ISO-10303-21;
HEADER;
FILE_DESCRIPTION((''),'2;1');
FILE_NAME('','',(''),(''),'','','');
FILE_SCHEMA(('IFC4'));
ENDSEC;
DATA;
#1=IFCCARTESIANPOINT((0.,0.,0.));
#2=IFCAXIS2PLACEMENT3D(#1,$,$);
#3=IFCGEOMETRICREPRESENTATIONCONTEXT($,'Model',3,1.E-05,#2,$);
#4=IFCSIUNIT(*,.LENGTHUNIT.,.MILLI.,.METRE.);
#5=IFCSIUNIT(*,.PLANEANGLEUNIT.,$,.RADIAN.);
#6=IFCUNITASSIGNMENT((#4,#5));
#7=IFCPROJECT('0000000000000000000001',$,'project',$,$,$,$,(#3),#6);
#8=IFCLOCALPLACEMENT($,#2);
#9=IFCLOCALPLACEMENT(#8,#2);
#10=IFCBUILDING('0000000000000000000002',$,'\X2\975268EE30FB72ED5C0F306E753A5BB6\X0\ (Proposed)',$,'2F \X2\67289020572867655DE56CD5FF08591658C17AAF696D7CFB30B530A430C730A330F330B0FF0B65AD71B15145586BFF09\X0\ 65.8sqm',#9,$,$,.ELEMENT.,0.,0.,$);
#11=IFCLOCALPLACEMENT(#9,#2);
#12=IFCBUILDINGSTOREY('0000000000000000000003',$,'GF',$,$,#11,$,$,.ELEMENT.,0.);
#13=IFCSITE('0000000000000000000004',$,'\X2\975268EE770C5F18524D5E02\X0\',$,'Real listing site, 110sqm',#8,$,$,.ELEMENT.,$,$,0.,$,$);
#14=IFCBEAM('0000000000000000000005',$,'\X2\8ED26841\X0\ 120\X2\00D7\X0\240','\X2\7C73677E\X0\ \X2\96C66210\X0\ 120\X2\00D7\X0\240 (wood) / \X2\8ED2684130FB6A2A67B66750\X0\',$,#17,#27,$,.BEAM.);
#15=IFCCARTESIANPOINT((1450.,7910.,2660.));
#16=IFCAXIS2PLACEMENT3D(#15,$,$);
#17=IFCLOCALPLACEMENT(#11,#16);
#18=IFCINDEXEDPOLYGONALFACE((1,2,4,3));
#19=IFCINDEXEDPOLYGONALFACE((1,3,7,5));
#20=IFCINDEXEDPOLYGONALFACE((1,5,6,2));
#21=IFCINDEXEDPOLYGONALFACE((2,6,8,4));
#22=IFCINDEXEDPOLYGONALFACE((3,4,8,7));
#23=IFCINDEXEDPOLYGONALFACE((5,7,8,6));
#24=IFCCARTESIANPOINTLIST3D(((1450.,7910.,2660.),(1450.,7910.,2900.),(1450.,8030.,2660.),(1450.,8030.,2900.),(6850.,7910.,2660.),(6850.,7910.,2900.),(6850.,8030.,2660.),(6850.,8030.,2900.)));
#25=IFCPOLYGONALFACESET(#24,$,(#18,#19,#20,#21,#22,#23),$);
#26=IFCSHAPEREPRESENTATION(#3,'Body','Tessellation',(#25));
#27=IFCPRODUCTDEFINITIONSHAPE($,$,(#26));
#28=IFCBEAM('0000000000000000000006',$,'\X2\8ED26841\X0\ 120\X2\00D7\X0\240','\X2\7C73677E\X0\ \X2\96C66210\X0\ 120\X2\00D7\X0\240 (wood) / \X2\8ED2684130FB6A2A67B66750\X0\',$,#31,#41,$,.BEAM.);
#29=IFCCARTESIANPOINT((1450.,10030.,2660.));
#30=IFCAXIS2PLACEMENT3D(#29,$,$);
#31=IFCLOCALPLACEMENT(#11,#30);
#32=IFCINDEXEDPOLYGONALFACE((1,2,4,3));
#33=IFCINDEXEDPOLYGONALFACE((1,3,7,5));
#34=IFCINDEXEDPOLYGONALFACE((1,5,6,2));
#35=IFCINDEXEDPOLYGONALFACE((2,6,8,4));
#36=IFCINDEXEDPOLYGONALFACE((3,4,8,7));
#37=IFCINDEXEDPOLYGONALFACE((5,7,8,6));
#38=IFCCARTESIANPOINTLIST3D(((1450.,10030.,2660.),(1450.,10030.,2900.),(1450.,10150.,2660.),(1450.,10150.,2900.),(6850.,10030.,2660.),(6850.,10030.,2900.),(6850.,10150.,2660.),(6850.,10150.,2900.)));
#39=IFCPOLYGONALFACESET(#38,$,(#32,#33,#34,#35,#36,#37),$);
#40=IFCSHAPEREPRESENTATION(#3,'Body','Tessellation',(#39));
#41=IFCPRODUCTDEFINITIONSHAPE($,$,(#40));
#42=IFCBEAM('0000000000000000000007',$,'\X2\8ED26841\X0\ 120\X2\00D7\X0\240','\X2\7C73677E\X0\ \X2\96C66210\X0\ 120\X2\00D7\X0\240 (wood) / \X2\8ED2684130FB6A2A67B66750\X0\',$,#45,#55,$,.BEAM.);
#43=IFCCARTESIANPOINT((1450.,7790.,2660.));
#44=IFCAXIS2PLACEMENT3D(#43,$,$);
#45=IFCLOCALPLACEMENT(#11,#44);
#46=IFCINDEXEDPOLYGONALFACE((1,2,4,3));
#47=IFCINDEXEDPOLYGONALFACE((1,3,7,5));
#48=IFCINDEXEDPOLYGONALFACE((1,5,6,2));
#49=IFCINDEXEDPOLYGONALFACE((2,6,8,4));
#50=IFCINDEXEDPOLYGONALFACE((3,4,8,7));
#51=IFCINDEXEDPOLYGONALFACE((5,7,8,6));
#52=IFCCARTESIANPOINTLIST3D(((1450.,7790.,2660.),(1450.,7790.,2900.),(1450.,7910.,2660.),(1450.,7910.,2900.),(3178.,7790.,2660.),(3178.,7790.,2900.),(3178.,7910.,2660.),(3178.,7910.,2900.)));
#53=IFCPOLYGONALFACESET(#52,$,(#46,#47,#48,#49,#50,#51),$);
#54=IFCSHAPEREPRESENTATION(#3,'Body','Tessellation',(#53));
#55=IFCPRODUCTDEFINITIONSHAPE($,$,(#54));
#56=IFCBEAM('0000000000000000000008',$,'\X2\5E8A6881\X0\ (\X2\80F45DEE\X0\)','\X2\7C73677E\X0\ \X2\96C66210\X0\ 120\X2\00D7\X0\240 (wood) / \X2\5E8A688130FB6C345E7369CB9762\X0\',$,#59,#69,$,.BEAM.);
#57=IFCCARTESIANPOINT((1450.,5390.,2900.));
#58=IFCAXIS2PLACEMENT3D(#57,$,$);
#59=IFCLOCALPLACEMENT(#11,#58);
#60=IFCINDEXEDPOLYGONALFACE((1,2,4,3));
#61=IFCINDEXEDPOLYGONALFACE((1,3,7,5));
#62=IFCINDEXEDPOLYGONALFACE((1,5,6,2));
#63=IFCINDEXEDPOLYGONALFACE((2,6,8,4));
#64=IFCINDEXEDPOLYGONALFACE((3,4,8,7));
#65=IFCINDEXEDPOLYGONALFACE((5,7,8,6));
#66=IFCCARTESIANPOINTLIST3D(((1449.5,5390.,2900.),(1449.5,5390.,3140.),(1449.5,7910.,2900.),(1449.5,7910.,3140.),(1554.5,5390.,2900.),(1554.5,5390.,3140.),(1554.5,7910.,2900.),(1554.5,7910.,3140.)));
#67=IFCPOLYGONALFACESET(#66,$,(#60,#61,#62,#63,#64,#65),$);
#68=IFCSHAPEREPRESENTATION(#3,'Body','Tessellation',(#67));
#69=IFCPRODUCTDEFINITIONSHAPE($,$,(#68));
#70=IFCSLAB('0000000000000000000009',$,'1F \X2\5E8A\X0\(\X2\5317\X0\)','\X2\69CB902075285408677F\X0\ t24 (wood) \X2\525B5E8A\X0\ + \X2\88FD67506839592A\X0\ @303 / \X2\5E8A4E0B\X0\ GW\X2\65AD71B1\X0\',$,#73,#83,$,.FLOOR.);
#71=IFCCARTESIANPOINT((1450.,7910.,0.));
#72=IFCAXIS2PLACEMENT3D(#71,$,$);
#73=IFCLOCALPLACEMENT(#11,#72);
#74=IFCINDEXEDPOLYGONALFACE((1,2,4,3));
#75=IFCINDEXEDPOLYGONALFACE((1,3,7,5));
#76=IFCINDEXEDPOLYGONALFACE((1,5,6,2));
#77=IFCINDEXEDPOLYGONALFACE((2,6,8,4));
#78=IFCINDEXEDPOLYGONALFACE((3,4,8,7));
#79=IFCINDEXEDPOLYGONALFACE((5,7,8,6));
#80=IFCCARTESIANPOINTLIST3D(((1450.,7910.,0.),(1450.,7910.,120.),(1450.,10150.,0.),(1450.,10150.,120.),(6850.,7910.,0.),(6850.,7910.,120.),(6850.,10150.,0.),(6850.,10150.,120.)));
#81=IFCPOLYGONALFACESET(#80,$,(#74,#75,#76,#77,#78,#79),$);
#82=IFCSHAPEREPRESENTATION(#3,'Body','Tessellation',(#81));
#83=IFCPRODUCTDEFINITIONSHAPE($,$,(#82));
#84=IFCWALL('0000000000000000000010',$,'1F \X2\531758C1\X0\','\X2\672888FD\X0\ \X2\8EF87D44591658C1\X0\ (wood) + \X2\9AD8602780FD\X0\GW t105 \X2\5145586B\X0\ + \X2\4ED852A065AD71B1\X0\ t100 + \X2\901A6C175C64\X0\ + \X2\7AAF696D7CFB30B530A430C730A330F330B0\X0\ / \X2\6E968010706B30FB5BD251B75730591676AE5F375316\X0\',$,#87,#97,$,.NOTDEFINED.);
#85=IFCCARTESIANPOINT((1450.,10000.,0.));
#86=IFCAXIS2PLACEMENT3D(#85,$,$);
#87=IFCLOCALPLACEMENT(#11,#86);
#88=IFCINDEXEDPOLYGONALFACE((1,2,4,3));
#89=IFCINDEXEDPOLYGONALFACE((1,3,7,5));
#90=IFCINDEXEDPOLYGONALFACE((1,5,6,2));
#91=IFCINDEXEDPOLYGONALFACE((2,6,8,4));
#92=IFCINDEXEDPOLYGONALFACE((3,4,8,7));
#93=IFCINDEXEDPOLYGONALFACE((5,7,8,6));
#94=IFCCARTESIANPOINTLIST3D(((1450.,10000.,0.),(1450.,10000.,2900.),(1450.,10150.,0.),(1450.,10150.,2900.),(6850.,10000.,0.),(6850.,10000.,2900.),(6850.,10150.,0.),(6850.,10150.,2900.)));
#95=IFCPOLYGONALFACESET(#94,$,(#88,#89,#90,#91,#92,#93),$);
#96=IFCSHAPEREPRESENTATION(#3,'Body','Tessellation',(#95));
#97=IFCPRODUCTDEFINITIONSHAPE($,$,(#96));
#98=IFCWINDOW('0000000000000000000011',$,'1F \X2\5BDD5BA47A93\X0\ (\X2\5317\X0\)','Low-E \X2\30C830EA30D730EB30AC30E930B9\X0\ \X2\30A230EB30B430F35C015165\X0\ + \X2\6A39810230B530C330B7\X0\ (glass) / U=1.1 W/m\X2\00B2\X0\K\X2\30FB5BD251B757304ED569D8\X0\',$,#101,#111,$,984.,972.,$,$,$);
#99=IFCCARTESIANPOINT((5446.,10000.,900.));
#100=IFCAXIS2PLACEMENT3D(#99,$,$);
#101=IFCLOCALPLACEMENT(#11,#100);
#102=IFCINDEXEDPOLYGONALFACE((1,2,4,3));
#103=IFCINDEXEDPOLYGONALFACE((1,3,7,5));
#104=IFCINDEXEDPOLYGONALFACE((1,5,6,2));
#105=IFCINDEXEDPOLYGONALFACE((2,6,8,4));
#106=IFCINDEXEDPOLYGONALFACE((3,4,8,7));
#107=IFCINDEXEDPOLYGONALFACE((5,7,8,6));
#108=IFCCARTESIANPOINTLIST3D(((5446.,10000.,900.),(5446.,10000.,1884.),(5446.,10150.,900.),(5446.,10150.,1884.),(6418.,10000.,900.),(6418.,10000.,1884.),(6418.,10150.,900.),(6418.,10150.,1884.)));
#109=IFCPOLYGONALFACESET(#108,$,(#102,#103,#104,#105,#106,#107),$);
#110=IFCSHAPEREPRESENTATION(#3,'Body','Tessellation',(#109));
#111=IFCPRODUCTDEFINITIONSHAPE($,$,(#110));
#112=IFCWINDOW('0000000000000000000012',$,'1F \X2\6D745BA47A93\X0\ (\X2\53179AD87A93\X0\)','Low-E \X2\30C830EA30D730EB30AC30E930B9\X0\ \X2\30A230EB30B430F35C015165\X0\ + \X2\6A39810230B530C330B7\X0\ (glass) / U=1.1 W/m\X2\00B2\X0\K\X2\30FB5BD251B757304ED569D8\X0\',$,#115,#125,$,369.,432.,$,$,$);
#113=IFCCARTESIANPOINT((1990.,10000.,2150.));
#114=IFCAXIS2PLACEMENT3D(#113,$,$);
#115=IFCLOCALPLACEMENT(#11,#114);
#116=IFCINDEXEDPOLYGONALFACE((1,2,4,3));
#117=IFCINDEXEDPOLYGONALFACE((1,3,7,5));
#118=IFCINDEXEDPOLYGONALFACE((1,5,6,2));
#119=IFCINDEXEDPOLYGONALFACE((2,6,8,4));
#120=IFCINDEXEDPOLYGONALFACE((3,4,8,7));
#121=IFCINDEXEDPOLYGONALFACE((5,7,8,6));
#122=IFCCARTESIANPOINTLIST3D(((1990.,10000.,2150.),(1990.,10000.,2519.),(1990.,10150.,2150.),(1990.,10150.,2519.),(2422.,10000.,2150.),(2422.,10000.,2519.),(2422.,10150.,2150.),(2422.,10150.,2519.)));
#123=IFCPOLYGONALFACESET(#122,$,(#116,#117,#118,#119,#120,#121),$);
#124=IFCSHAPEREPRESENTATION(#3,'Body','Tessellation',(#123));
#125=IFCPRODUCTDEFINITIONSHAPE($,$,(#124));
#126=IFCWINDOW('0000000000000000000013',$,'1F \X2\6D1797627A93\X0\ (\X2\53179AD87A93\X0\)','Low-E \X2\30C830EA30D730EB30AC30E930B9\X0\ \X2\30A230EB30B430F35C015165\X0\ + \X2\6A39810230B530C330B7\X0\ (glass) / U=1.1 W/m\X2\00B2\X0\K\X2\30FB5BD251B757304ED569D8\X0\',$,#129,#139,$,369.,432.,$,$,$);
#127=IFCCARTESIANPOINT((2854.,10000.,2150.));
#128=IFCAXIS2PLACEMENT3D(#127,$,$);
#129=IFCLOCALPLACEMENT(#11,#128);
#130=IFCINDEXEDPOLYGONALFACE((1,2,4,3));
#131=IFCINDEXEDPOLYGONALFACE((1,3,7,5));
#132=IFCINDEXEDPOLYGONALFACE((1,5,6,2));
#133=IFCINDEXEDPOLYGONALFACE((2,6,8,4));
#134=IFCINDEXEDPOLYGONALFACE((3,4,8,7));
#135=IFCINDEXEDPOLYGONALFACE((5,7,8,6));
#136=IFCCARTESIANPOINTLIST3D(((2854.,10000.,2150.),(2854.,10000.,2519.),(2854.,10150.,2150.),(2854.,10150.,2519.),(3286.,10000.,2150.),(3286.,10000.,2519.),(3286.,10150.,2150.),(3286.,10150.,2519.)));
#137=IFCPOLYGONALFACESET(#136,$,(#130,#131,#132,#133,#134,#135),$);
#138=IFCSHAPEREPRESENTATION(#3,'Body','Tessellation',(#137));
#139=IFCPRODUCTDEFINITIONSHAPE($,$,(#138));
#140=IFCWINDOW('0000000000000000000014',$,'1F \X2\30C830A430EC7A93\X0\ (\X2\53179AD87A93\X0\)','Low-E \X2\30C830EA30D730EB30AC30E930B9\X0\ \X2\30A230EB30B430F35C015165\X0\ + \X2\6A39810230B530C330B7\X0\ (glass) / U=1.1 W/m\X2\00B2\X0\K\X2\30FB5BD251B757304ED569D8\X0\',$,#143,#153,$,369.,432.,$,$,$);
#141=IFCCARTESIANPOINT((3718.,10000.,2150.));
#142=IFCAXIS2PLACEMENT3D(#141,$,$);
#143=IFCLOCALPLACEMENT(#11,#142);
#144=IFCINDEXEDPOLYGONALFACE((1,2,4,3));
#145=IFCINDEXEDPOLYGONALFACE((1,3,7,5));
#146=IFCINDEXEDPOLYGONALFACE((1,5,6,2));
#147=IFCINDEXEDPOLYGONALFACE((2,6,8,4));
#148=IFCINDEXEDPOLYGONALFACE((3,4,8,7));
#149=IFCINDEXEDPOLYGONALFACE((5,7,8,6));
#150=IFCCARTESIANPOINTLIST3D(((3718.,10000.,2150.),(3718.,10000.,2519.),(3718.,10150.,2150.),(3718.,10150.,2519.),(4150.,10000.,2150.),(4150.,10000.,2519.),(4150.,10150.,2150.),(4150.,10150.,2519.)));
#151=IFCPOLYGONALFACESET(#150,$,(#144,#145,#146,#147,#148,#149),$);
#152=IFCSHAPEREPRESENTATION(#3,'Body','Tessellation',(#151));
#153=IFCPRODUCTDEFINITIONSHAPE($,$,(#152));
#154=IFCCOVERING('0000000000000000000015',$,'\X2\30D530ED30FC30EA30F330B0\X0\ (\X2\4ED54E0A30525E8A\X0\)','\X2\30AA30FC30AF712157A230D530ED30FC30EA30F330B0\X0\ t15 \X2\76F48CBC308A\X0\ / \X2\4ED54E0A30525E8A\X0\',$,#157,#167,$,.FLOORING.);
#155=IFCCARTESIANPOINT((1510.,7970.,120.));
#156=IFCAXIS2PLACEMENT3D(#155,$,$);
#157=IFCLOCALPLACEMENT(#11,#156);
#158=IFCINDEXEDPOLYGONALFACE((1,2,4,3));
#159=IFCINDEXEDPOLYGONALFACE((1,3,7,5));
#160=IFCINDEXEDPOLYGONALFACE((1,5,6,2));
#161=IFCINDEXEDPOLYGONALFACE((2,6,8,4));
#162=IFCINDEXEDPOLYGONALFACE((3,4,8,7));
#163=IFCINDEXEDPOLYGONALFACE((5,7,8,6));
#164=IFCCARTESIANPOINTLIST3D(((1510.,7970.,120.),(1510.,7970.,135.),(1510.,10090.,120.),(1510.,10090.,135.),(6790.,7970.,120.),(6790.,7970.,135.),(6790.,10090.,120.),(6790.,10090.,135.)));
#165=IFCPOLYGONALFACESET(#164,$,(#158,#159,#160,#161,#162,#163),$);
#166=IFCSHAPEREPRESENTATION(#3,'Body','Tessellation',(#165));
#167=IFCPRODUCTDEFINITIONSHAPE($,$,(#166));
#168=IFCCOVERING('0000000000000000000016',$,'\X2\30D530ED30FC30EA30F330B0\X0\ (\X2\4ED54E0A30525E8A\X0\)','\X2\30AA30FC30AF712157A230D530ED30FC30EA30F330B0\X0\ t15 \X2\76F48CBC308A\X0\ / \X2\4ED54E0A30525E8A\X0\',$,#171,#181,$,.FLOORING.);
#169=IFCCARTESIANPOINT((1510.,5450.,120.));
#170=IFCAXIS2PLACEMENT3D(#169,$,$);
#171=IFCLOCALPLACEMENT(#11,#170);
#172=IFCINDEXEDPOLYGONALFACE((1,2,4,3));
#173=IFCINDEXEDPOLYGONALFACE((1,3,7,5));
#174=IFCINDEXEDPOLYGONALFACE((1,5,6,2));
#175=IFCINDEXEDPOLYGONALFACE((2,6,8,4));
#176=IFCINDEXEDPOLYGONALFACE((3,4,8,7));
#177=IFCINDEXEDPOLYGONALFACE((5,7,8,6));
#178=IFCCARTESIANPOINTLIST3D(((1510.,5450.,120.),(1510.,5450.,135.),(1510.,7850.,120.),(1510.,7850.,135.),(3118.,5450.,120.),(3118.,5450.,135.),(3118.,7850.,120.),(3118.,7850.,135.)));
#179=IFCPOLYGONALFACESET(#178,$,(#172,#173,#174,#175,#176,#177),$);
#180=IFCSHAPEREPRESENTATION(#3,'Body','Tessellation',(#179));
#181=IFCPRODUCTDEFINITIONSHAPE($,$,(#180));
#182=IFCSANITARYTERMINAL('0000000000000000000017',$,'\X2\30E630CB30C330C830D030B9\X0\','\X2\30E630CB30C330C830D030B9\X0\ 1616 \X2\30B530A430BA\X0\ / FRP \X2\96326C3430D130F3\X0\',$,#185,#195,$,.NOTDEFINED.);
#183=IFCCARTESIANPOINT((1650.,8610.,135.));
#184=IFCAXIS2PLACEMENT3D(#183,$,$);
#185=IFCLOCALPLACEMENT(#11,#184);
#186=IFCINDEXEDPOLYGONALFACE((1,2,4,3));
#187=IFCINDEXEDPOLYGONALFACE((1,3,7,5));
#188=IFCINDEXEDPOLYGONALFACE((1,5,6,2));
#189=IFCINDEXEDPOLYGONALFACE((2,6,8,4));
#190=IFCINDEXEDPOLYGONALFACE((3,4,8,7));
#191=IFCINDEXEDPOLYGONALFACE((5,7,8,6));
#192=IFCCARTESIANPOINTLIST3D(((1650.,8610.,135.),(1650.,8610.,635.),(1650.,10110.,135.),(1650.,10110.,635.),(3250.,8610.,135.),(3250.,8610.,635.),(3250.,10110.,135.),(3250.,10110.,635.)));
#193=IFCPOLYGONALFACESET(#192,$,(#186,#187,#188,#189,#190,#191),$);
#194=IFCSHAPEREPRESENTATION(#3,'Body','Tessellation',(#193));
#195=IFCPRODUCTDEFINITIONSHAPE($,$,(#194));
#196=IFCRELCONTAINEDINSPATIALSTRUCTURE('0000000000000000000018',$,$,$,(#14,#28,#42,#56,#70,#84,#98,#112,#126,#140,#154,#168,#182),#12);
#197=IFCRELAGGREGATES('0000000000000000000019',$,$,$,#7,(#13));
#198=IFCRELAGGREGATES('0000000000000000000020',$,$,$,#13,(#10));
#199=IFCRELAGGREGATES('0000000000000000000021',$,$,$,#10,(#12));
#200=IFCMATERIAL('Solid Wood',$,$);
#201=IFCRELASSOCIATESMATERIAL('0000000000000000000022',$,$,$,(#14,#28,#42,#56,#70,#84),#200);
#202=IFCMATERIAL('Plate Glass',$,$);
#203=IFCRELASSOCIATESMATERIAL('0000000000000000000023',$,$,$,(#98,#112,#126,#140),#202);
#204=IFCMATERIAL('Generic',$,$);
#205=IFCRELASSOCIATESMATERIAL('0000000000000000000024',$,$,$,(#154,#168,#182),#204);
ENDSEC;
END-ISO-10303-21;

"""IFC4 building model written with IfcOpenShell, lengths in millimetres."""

from ifc_helpers import new_model, si_unit, frame, frame_2d, origin, place, context, project, spatial, rectangle, extrude, material, element, fill, save


model = new_model("IFC4")

# Units and contexts
model_context = context("Model", 3, precision=1e-05, world=origin())
ifc_project = project(units=[si_unit("LENGTHUNIT", "METRE", prefix="MILLI"), si_unit("PLANEANGLEUNIT", "RADIAN")], contexts=[model_context])

# Site, building, storey
site_placement = place(None, origin())
site = spatial("IfcSite", under=ifc_project, at=site_placement, Name="青森県弘前市", ObjectType="Real listing site, 110sqm", CompositionType="ELEMENT", RefElevation=0.0)
building_placement = place(site_placement, origin())
building = spatial("IfcBuilding", under=site, at=building_placement, Name="青森・狭小の町家 (Proposed)", ObjectType="2F 木造在来工法（外壁窯業系サイディング＋断熱充填） 65.8sqm", CompositionType="ELEMENT", ElevationOfRefHeight=0.0, ElevationOfTerrain=0.0)
storey_placement = place(building_placement, origin())
storey = spatial("IfcBuildingStorey", under=building, at=storey_placement, Name="GF", CompositionType="ELEMENT", Elevation=0.0)

# Shared definitions
ifc_material_1 = material(Name="Solid Wood")

# Beams
beam_1_placement = place(storey_placement, frame((1450.0, 7910.0, 2660.0)))
element("IfcBeam", 1, at=beam_1_placement, inside=storey, material=ifc_material_1, Name="軒桁 120×240", Description="米松 集成 120×240 (wood) / 軒桁・横架材", PredefinedType="BEAM", context=model_context, shape_type="SweptSolid", body=[
    extrude(rectangle(XDim=5400.0, YDim=120.0, at=frame_2d((2700.0, 60.0))), frame((1450.0, 7910.0, 2660.0)), (0.0, 0.0, 1.0), 240.0),
])
beam_2_placement = place(storey_placement, frame((1450.0, 10030.0, 2660.0)))
element("IfcBeam", 2, at=beam_2_placement, inside=storey, material=ifc_material_1, Name="軒桁 120×240", Description="米松 集成 120×240 (wood) / 軒桁・横架材", PredefinedType="BEAM", context=model_context, shape_type="SweptSolid", body=[
    extrude(rectangle(XDim=5400.0, YDim=120.0, at=frame_2d((2700.0, 60.0))), frame((1450.0, 10030.0, 2660.0)), (0.0, 0.0, 1.0), 240.0),
])
beam_3_placement = place(storey_placement, frame((1450.0, 7790.0, 2660.0)))
element("IfcBeam", 3, at=beam_3_placement, inside=storey, material=ifc_material_1, Name="軒桁 120×240", Description="米松 集成 120×240 (wood) / 軒桁・横架材", PredefinedType="BEAM", context=model_context, shape_type="SweptSolid", body=[
    extrude(rectangle(XDim=1728.0, YDim=120.0, at=frame_2d((864.0, 60.0))), frame((1450.0, 7790.0, 2660.0)), (0.0, 0.0, 1.0), 240.0),
])
beam_4_placement = place(storey_placement, frame((1450.0, 5390.0, 2900.0)))
element("IfcBeam", 4, at=beam_4_placement, inside=storey, material=ifc_material_1, Name="床梁 (胴差)", Description="米松 集成 120×240 (wood) / 床梁・水平構面", PredefinedType="BEAM", context=model_context, shape_type="SweptSolid", body=[
    extrude(rectangle(XDim=105.0, YDim=2520.0, at=frame_2d((52.0, 1260.0))), frame((1450.0, 5390.0, 2900.0)), (0.0, 0.0, 1.0), 240.0),
])

# Slab
slab_placement = place(storey_placement, frame((1450.0, 7910.0, 0.0)))
element("IfcSlab", 5, at=slab_placement, inside=storey, material=ifc_material_1, Name="1F 床(北)", Description="構造用合板 t24 (wood) 剛床 + 製材根太 @303 / 床下 GW断熱", PredefinedType="FLOOR", context=model_context, shape_type="SweptSolid", body=[
    extrude(rectangle(XDim=5400.0, YDim=2240.0, at=frame_2d((2700.0, 1120.0))), frame((1450.0, 7910.0, 0.0)), (0.0, 0.0, 1.0), 120.0),
])

# Wall, openings, windows
wall_1_placement = place(storey_placement, frame((1450.0, 10000.0, 0.0)))
wall_1 = element("IfcWall", 6, at=wall_1_placement, inside=storey, material=ifc_material_1, Name="1F 北壁", Description="木製 軸組外壁 (wood) + 高性能GW t105 充填 + 付加断熱 t100 + 通気層 + 窯業系サイディング / 準耐火・寒冷地外皮強化", PredefinedType="NOTDEFINED", context=model_context, shape_type="SweptSolid", body=[
    extrude(rectangle(XDim=5400.0, YDim=150.0, at=frame_2d((2700.0, 75.0))), frame((1450.0, 10000.0, 0.0)), (0.0, 0.0, 1.0), 2900.0),
])
opening_1_placement = place(storey_placement, frame((5446.0, 10000.0, 900.0)))
opening_1 = element("IfcOpeningElement", 7, at=opening_1_placement, cuts=wall_1, PredefinedType="NOTDEFINED", context=model_context, shape_type="SweptSolid", body=[
    extrude(rectangle(XDim=972.0, YDim=150.0, at=frame_2d((486.0, 75.0))), frame((5446.0, 10000.0, 900.0)), (0.0, 0.0, 1.0), 984.0),
])
opening_2_placement = place(storey_placement, frame((1990.0, 10000.0, 2150.0)))
opening_2 = element("IfcOpeningElement", 8, at=opening_2_placement, cuts=wall_1, PredefinedType="NOTDEFINED", context=model_context, shape_type="SweptSolid", body=[
    extrude(rectangle(XDim=432.0, YDim=150.0, at=frame_2d((216.0, 75.0))), frame((1990.0, 10000.0, 2150.0)), (0.0, 0.0, 1.0), 369.0),
])
opening_3_placement = place(storey_placement, frame((2854.0, 10000.0, 2150.0)))
opening_3 = element("IfcOpeningElement", 9, at=opening_3_placement, cuts=wall_1, PredefinedType="NOTDEFINED", context=model_context, shape_type="SweptSolid", body=[
    extrude(rectangle(XDim=432.0, YDim=150.0, at=frame_2d((216.0, 75.0))), frame((2854.0, 10000.0, 2150.0)), (0.0, 0.0, 1.0), 369.0),
])
opening_4_placement = place(storey_placement, frame((3718.0, 10000.0, 2150.0)))
opening_4 = element("IfcOpeningElement", 10, at=opening_4_placement, cuts=wall_1, PredefinedType="NOTDEFINED", context=model_context, shape_type="SweptSolid", body=[
    extrude(rectangle(XDim=432.0, YDim=150.0, at=frame_2d((216.0, 75.0))), frame((3718.0, 10000.0, 2150.0)), (0.0, 0.0, 1.0), 369.0),
])
ifc_material_2 = material(Name="Plate Glass")
window_1_placement = place(storey_placement, frame((5446.0, 10000.0, 900.0)))
window_1 = element("IfcWindow", 11, at=window_1_placement, inside=storey, material=ifc_material_2, Name="1F 寝室窓 (北)", Description="Low-E トリプルガラス アルゴン封入 + 樹脂サッシ (glass) / U=1.1 W/m²K・寒冷地仕様", OverallHeight=984.0, OverallWidth=972.0, context=model_context, shape_type="SweptSolid", body=[
    extrude(rectangle(XDim=972.0, YDim=150.0, at=frame_2d((486.0, 75.0))), frame((5446.0, 10000.0, 900.0)), (0.0, 0.0, 1.0), 984.0),
])
fill(opening_1, window_1)
window_2_placement = place(storey_placement, frame((1990.0, 10000.0, 2150.0)))
window_2 = element("IfcWindow", 12, at=window_2_placement, inside=storey, material=ifc_material_2, Name="1F 浴室窓 (北高窓)", Description="Low-E トリプルガラス アルゴン封入 + 樹脂サッシ (glass) / U=1.1 W/m²K・寒冷地仕様", OverallHeight=369.0, OverallWidth=432.0, context=model_context, shape_type="SweptSolid", body=[
    extrude(rectangle(XDim=432.0, YDim=150.0, at=frame_2d((216.0, 75.0))), frame((1990.0, 10000.0, 2150.0)), (0.0, 0.0, 1.0), 369.0),
])
fill(opening_2, window_2)
window_3_placement = place(storey_placement, frame((2854.0, 10000.0, 2150.0)))
window_3 = element("IfcWindow", 13, at=window_3_placement, inside=storey, material=ifc_material_2, Name="1F 洗面窓 (北高窓)", Description="Low-E トリプルガラス アルゴン封入 + 樹脂サッシ (glass) / U=1.1 W/m²K・寒冷地仕様", OverallHeight=369.0, OverallWidth=432.0, context=model_context, shape_type="SweptSolid", body=[
    extrude(rectangle(XDim=432.0, YDim=150.0, at=frame_2d((216.0, 75.0))), frame((2854.0, 10000.0, 2150.0)), (0.0, 0.0, 1.0), 369.0),
])
fill(opening_3, window_3)
window_4_placement = place(storey_placement, frame((3718.0, 10000.0, 2150.0)))
window_4 = element("IfcWindow", 14, at=window_4_placement, inside=storey, material=ifc_material_2, Name="1F トイレ窓 (北高窓)", Description="Low-E トリプルガラス アルゴン封入 + 樹脂サッシ (glass) / U=1.1 W/m²K・寒冷地仕様", OverallHeight=369.0, OverallWidth=432.0, context=model_context, shape_type="SweptSolid", body=[
    extrude(rectangle(XDim=432.0, YDim=150.0, at=frame_2d((216.0, 75.0))), frame((3718.0, 10000.0, 2150.0)), (0.0, 0.0, 1.0), 369.0),
])
fill(opening_4, window_4)

# Coverings
ifc_material_3 = material(Name="Generic")
covering_1_placement = place(storey_placement, frame((1510.0, 7970.0, 120.0)))
element("IfcCovering", 15, at=covering_1_placement, inside=storey, material=ifc_material_3, Name="フローリング (仕上げ床)", Description="オーク無垢フローリング t15 直貼り / 仕上げ床", PredefinedType="FLOORING", context=model_context, shape_type="SweptSolid", body=[
    extrude(rectangle(XDim=5280.0, YDim=2120.0, at=frame_2d((2640.0, 1060.0))), frame((1510.0, 7970.0, 120.0)), (0.0, 0.0, 1.0), 15.0),
])
covering_2_placement = place(storey_placement, frame((1510.0, 5450.0, 120.0)))
element("IfcCovering", 16, at=covering_2_placement, inside=storey, material=ifc_material_3, Name="フローリング (仕上げ床)", Description="オーク無垢フローリング t15 直貼り / 仕上げ床", PredefinedType="FLOORING", context=model_context, shape_type="SweptSolid", body=[
    extrude(rectangle(XDim=1608.0, YDim=2400.0, at=frame_2d((804.0, 1200.0))), frame((1510.0, 5450.0, 120.0)), (0.0, 0.0, 1.0), 15.0),
])

# Sanitary terminal
sanitary_terminal_placement = place(storey_placement, frame((1650.0, 8610.0, 135.0)))
element("IfcSanitaryTerminal", 17, at=sanitary_terminal_placement, inside=storey, material=ifc_material_3, Name="ユニットバス", Description="ユニットバス 1616 サイズ / FRP 防水パン", PredefinedType="NOTDEFINED", context=model_context, shape_type="SweptSolid", body=[
    extrude(rectangle(XDim=1600.0, YDim=1500.0, at=frame_2d((800.0, 750.0))), frame((1650.0, 8610.0, 135.0)), (0.0, 0.0, 1.0), 500.0),
])

save(model, "model.ifc")
